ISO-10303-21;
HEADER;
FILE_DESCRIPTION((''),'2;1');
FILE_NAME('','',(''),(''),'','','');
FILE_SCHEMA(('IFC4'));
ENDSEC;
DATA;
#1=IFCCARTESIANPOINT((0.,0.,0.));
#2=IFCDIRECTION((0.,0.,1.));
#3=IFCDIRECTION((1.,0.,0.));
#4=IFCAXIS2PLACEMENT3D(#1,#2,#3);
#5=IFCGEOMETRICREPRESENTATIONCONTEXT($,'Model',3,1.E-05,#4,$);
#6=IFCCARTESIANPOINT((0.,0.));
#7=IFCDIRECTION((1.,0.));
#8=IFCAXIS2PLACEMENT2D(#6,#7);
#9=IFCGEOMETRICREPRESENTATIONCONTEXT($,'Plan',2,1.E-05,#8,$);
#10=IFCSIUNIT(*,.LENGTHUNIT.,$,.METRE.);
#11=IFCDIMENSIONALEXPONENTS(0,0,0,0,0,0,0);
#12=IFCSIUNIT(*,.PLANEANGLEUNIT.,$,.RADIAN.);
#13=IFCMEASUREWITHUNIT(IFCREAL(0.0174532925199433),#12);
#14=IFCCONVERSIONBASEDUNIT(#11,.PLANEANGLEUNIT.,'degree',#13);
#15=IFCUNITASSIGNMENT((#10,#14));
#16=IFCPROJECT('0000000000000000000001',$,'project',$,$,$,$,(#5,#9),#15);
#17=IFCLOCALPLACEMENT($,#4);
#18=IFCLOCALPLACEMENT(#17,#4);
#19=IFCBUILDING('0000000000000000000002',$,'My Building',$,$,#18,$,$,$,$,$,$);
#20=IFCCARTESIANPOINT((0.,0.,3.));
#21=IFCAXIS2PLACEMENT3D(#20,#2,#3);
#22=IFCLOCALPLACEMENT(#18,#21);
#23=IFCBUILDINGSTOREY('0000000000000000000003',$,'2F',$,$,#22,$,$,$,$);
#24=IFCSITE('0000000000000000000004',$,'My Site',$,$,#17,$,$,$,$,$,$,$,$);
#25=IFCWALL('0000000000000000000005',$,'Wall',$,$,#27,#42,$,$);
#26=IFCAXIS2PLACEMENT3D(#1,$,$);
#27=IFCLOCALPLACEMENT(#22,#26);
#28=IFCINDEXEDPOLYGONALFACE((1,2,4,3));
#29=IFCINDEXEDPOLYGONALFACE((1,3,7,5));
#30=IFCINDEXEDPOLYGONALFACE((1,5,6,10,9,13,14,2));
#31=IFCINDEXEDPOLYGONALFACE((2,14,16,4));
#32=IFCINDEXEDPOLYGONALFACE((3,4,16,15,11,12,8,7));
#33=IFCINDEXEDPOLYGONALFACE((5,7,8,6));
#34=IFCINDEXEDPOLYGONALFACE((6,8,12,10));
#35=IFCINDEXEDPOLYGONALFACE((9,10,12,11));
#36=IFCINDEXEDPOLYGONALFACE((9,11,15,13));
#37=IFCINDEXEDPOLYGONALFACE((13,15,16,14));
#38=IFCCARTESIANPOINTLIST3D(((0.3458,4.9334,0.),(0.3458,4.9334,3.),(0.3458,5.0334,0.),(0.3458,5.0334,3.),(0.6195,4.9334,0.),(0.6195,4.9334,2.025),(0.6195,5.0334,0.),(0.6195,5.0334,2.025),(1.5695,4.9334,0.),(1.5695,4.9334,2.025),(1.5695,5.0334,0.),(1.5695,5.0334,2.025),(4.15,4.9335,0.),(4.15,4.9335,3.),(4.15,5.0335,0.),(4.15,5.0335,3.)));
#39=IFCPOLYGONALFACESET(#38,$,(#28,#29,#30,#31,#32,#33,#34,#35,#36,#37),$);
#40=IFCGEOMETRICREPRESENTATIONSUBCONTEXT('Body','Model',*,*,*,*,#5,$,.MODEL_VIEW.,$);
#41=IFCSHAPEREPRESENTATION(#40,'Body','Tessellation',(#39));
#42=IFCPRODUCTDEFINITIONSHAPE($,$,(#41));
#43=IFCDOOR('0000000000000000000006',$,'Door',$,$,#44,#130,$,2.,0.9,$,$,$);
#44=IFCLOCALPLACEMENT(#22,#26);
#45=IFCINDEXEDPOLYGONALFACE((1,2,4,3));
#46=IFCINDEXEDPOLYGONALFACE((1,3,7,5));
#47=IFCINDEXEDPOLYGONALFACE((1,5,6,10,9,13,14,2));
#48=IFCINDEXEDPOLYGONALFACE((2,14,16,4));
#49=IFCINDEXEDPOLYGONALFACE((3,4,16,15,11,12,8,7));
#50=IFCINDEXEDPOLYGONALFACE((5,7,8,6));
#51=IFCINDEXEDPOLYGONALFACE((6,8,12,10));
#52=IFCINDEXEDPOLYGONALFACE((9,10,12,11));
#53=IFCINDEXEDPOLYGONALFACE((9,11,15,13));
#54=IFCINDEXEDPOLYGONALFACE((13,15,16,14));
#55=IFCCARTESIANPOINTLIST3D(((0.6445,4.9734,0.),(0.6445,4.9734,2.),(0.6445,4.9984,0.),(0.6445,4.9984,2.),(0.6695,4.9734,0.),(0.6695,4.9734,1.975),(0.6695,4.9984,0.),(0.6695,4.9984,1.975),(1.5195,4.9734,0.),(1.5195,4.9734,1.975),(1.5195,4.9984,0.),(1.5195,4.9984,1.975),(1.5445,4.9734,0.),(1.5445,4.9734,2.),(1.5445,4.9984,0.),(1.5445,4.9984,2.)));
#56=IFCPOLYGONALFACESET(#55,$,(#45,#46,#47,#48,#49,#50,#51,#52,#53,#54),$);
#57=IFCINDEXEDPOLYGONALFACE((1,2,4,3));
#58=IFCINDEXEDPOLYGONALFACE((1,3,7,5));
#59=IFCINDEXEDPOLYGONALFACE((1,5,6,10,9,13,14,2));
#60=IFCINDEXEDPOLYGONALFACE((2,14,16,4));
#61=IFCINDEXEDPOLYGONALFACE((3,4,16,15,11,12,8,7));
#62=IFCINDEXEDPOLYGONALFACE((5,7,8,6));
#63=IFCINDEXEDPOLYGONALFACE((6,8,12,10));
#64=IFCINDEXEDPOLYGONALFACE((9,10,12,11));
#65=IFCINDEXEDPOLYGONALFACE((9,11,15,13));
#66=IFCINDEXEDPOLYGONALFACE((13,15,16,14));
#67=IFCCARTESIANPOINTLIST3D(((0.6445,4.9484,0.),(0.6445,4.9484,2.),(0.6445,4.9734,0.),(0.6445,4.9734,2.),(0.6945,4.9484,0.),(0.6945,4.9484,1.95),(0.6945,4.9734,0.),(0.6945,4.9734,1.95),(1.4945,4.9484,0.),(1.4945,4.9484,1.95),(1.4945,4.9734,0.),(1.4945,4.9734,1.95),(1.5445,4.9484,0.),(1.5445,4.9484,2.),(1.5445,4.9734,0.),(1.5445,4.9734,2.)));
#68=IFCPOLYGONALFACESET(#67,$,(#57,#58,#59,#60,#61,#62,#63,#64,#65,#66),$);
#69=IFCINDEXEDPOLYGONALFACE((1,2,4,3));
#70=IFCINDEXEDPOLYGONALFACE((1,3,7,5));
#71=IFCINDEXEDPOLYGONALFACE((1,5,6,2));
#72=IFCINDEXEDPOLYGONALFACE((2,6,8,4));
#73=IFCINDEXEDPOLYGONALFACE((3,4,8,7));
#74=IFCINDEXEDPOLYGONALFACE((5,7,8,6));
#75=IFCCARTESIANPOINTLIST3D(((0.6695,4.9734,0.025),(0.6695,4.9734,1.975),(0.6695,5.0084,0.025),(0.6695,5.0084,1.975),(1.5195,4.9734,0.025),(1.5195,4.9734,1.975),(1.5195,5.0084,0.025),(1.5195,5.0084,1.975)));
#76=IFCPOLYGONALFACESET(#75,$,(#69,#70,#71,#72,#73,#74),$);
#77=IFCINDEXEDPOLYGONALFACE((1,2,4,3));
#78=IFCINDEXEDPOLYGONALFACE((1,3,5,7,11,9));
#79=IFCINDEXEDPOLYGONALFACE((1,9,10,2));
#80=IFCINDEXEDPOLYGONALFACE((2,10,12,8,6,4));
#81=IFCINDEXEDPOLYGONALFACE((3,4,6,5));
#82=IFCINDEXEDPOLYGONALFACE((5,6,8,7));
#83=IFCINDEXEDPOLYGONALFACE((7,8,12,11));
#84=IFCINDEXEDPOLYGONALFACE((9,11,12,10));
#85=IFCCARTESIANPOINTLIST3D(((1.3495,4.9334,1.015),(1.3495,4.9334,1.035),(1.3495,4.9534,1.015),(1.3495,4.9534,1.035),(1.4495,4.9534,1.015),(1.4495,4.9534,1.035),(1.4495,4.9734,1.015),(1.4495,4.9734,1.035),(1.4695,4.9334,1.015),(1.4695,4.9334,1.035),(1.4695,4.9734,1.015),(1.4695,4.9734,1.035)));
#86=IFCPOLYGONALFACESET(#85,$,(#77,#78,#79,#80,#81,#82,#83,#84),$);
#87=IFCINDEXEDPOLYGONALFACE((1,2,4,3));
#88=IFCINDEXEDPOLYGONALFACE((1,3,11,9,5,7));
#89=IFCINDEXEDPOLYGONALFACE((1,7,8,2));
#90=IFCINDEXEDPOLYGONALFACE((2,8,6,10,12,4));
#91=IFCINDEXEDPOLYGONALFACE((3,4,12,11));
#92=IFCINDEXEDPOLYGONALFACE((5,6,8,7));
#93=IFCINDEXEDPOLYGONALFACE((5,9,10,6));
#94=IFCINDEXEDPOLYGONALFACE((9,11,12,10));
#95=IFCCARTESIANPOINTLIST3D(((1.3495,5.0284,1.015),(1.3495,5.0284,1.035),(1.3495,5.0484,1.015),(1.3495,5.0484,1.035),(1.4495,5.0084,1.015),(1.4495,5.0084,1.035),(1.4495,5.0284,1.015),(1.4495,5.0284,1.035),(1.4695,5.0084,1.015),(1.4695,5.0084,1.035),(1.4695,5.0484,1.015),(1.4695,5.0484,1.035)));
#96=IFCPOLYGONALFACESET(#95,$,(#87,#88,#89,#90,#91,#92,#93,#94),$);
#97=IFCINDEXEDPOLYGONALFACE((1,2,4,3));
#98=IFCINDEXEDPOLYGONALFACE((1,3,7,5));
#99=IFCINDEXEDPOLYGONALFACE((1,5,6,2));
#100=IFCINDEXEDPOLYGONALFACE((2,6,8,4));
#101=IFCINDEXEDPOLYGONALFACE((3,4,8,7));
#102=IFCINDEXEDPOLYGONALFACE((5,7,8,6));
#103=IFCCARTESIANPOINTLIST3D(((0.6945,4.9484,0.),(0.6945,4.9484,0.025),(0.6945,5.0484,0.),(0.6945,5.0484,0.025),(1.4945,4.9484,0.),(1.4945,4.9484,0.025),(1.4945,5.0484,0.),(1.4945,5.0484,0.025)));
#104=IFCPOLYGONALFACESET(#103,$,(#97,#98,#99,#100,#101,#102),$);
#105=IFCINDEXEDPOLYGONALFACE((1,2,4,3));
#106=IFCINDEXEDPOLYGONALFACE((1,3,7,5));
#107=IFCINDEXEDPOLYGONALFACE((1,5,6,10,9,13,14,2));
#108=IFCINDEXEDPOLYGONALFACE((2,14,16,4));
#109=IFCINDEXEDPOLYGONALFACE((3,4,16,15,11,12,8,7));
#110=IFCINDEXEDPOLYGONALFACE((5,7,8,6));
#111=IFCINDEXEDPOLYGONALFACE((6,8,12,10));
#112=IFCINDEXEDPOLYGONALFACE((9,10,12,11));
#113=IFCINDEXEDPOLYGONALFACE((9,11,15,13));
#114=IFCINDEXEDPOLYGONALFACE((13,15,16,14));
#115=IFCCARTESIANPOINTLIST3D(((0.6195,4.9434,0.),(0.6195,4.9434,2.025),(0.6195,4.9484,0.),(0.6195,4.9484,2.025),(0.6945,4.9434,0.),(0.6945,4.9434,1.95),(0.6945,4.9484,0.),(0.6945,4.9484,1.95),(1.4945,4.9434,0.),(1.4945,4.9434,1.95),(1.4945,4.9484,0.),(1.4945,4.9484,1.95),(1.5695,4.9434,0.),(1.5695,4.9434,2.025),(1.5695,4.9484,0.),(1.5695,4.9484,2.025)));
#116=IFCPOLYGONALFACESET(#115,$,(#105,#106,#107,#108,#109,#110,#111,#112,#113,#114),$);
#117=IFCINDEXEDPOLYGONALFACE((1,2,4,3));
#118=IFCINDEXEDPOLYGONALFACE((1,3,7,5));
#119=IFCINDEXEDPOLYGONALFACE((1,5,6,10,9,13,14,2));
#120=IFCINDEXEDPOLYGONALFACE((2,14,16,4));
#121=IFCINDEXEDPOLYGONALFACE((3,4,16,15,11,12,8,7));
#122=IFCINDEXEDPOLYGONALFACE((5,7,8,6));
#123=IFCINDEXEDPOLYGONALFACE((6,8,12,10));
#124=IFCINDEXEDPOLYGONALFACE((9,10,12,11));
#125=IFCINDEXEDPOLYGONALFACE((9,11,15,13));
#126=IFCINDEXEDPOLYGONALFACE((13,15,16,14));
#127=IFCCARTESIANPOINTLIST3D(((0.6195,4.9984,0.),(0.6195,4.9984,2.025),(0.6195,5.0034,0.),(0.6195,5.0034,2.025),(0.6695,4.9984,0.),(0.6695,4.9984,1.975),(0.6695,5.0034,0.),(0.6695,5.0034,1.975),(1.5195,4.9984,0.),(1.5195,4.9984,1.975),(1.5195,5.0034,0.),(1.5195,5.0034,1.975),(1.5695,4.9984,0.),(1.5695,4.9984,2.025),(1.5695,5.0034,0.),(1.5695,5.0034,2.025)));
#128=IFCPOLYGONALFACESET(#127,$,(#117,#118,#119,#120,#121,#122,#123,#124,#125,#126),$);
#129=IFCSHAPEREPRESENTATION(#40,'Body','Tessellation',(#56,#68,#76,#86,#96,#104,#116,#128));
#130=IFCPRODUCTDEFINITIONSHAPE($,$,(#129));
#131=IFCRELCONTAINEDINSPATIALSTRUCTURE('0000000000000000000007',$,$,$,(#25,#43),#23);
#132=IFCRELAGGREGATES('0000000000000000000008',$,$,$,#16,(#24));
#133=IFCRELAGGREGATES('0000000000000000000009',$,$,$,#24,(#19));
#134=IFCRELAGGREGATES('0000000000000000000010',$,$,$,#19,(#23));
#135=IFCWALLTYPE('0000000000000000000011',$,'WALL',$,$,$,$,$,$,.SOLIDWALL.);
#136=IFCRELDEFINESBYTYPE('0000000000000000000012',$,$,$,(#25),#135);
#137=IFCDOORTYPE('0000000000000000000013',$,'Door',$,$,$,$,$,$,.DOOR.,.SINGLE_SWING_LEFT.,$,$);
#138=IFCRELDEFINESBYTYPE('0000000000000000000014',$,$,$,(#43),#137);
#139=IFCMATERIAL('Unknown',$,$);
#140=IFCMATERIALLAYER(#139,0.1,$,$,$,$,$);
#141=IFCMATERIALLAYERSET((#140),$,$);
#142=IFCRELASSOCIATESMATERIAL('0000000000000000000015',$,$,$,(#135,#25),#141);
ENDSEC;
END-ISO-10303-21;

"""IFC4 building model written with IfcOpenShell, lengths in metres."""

from ifc_helpers import new_model, entity, si_unit, converted_unit, frame, origin_with_axes, origin_2d_with_axis, place, context, subcontext, project, spatial, line, indexed_curve, outline, extrude, shape, source, transform, mapped, material, layer, layer_set, layer_usage, type_object, type_shapes, element, fill, save


model = new_model("IFC4")

# Units and contexts
model_context = context("Model", 3, precision=1e-05, world=origin_with_axes())
plan_context = context("Plan", 2, precision=1e-05, world=origin_2d_with_axis())
body_context_1 = subcontext(model_context, "Body", "Model", "MODEL_VIEW")
body_context_2 = subcontext(plan_context, "Body", "Plan", "PLAN_VIEW")
ifc_project = project(units=[si_unit("LENGTHUNIT", "METRE"), converted_unit("PLANEANGLEUNIT", "degree", entity("IfcReal", 0.0174532925199433), si_unit("PLANEANGLEUNIT", "RADIAN"), dimensions=[0, 0, 0, 0, 0, 0, 0])], contexts=[model_context, plan_context])

# Site, building, storey
site_placement = place(None, origin_with_axes())
site = spatial("IfcSite", under=ifc_project, at=site_placement, Name="My Site")
building_placement = place(site_placement, origin_with_axes())
building = spatial("IfcBuilding", under=site, at=building_placement, Name="My Building")
storey_placement = place(building_placement, frame((0.0, 0.0, 3.0), z_axis=(0.0, 0.0, 1.0), x_axis=(1.0, 0.0, 0.0)))
storey = spatial("IfcBuildingStorey", under=building, at=storey_placement, Name="2F")

# Shared definitions
ifc_material = material(Name="Unknown")

# Shared definitions
ifc_layer_1 = layer(ifc_material, 0.1)
ifc_layer_set_1 = layer_set([ifc_layer_1])
wall_type = type_object("IfcWallType", Name="WALL", PredefinedType="SOLIDWALL", material=ifc_layer_set_1)

# Shared definitions
shared_shape_1 = source(origin_with_axes(), body_context_1, "Body", "SweptSolid", [
    extrude(outline(indexed_curve([(0.0, 0.0), (0.9, 0.0), (0.9, 2.0), (0.0, 2.0)], segments=[line(1, 2, 3, 4, 1)])), frame((0.0, -0.6, 0.0), z_axis=(0.0, -1.0, 0.0), x_axis=(1.0, 0.0, 0.0)), (0.0, 0.0, -1.0), 1.2),
])
door_type = type_object("IfcDoorType", Name="Door", OperationType="SINGLE_SWING_LEFT", PredefinedType="DOOR")
shared_shape_2 = source(origin_with_axes(), body_context_1, "Body", "SweptSolid", [
    extrude(outline(indexed_curve([(0.0, 0.0), (0.0, 2.0), (0.9, 2.0), (0.9, 0.0), (0.875, 0.0), (0.875, 1.975), (0.025, 1.975), (0.025, 0.0)], segments=[line(1, 2, 3, 4, 5, 6, 7, 8, 1)])), frame((0.0, 0.025, 0.0), z_axis=(0.0, -1.0, 0.0), x_axis=(1.0, 0.0, 0.0)), (0.0, 0.0, -1.0), 0.025),
    extrude(outline(indexed_curve([(0.0, 0.0), (0.0, 2.0), (0.9, 2.0), (0.9, 0.0), (0.85, 0.0), (0.85, 1.95), (0.05, 1.95), (0.05, 0.0)], segments=[line(1, 2, 3, 4, 5, 6, 7, 8, 1)])), frame((0.0, 0.0, 0.0), z_axis=(0.0, -1.0, 0.0), x_axis=(1.0, 0.0, 0.0)), (0.0, 0.0, -1.0), 0.025),
    extrude(outline(indexed_curve([(0.0, 0.0), (0.85, 0.0), (0.85, 0.035), (0.0, 0.035)], segments=[line(1, 2, 3, 4, 1)])), frame((0.025, 0.025, 0.025), z_axis=(0.0, 0.0, 1.0), x_axis=(1.0, 0.0, 0.0)), (0.0, 0.0, 1.0), 1.95),
    extrude(outline(indexed_curve([(0.0, 0.0), (0.0, -0.04), (-0.12, -0.04), (-0.12, -0.02), (-0.02, -0.02), (-0.02, 0.0)], segments=[line(1, 2, 3, 4, 5, 6, 1)])), frame((0.825, 0.025, 1.015), z_axis=(0.0, 0.0, 1.0), x_axis=(1.0, 0.0, 0.0)), (0.0, 0.0, 1.0), 0.02),
    extrude(outline(indexed_curve([(0.0, 0.0), (0.0, 0.04), (-0.12, 0.04), (-0.12, 0.02), (-0.02, 0.02), (-0.02, 0.0)], segments=[line(1, 2, 3, 4, 5, 6, 1)])), frame((0.825, 0.06, 1.015), z_axis=(0.0, 0.0, 1.0), x_axis=(1.0, 0.0, 0.0)), (0.0, 0.0, 1.0), 0.02),
    extrude(outline(indexed_curve([(0.0, 0.0), (0.8, 0.0), (0.8, 0.1), (0.0, 0.1)], segments=[line(1, 2, 3, 4, 1)])), frame((0.05, 0.0, 0.0), z_axis=(0.0, 0.0, 1.0), x_axis=(1.0, 0.0, 0.0)), (0.0, 0.0, 1.0), 0.025),
    extrude(outline(indexed_curve([(0.0, 0.0), (0.0, 2.025), (0.95, 2.025), (0.95, 0.0), (0.875, 0.0), (0.875, 1.95), (0.075, 1.95), (0.075, 0.0)], segments=[line(1, 2, 3, 4, 5, 6, 7, 8, 1)])), frame((-0.025, -0.005, 0.0), z_axis=(0.0, -1.0, 0.0), x_axis=(1.0, 0.0, 0.0)), (0.0, 0.0, -1.0), 0.005),
    extrude(outline(indexed_curve([(0.0, 0.0), (0.0, 2.025), (0.95, 2.025), (0.95, 0.0), (0.9, 0.0), (0.9, 1.975), (0.05, 1.975), (0.05, 0.0)], segments=[line(1, 2, 3, 4, 5, 6, 7, 8, 1)])), frame((-0.025, 0.05, 0.0), z_axis=(0.0, -1.0, 0.0), x_axis=(1.0, 0.0, 0.0)), (0.0, 0.0, -1.0), 0.005),
])
shared_shape_3 = source(origin_with_axes(), body_context_2, "Body", "Curve2D", [
    entity("IfcIndexedPolyCurve", entity("IfcCartesianPointList2D", [[0.0, 0.0], [0.0, 0.05], [0.025, 0.05], [0.025, 0.025], [0.05, 0.025], [0.05, 0.0]]), [entity("IfcLineIndex", [1, 2, 3, 4, 5, 6, 1])]),
    entity("IfcIndexedPolyCurve", entity("IfcCartesianPointList2D", [[0.9, 0.0], [0.9, 0.05], [0.875, 0.05], [0.875, 0.025], [0.85, 0.025], [0.85, 0.0]]), [entity("IfcLineIndex", [1, 2, 3, 4, 5, 6, 1])]),
    entity("IfcTrimmedCurve", entity("IfcEllipse", entity("IfcAxis2Placement2D", entity("IfcCartesianPoint", [0.06, 0.05]), entity("IfcDirection", [1.0, 0.0])), 0.815, 0.85), [entity("IfcCartesianPoint", [0.875, 0.05])], [entity("IfcCartesianPoint", [0.06, 0.9])], True, "CARTESIAN"),
    entity("IfcIndexedPolyCurve", entity("IfcCartesianPointList2D", [[0.025, 0.05], [0.06, 0.05], [0.06, 0.9], [0.025, 0.9]]), [entity("IfcLineIndex", [1, 2, 3, 4, 1])]),
])
type_shapes(door_type, [shared_shape_2, shared_shape_3])

# Wall, openings, door
ifc_layer_usage_1 = layer_usage(ifc_layer_set_1, "AXIS2", "POSITIVE", 0.0)
wall_1_placement = place(storey_placement, frame((4.15, 5.0335, 0.0), z_axis=(0.0, 0.0, 1.0), x_axis=(-1.0, -0.000042, 0.0)))
wall_1 = element("IfcWall", 1, at=wall_1_placement, inside=storey, type_object=wall_type, material=ifc_layer_usage_1, Name="Wall", context=body_context_1, shape_type="SweptSolid", body=[
    extrude(outline(indexed_curve([(0.0, 0.0), (0.0, 0.1), (3.8042, 0.1), (3.8042, 0.0)], segments=[line(1, 2, 3, 4, 1)])), origin_with_axes(), (0.0, 0.0, 1.0), 3.0),
])
opening_1_placement = place(wall_1_placement, frame((2.6055, 0.0, 0.0), z_axis=(0.0, 0.0, 1.0), x_axis=(1.0, 0.0, 0.0)))
opening_1 = element("IfcOpeningElement", 2, at=opening_1_placement, cuts=wall_1, PredefinedType="OPENING", context=body_context_1, shape_type="MappedRepresentation", body=[
    mapped(shared_shape_1, transform((0.0, 0.0, 0.0), x_axis=(1.0, 0.0, 0.0), y_axis=(0.0, 1.0, 0.0), z_axis=(0.0, 0.0, 1.0), scale=1.0)),
])
shared_shape_4 = source(origin_with_axes(), body_context_1, "Body", "SweptSolid", [
    extrude(outline(indexed_curve([(0.0, 0.0), (0.95, 0.0), (0.95, 2.025), (0.0, 2.025)], segments=[line(1, 2, 3, 4, 1)])), frame((-0.025, -0.6, 0.0), z_axis=(0.0, -1.0, 0.0), x_axis=(1.0, 0.0, 0.0)), (0.0, 0.0, -1.0), 1.2),
])
opening_2_placement = place(wall_1_placement, frame((2.6055, 0.0, 0.0), z_axis=(0.0, 0.0, 1.0), x_axis=(1.0, 0.0, 0.0)))
element("IfcOpeningElement", 3, at=opening_2_placement, cuts=wall_1, PredefinedType="OPENING", context=body_context_1, shape_type="MappedRepresentation", body=[
    mapped(shared_shape_4, transform((0.0, 0.0, 0.0), x_axis=(1.0, 0.0, 0.0), y_axis=(0.0, 1.0, 0.0), z_axis=(0.0, 0.0, 1.0), scale=1.0)),
])
door_1_placement = place(opening_1_placement, frame((0.9, 0.085, 0.0), z_axis=(0.0, 0.0, 1.0), x_axis=(-1.0, 0.0, 0.0)))
door_1 = element("IfcDoor", 4, at=door_1_placement, inside=storey, type_object=door_type, Name="Door", OverallHeight=2.0, OverallWidth=0.9, shapes=[
    shape(body_context_1, "Body", "MappedRepresentation", [mapped(shared_shape_2, transform((0.0, 0.0, 0.0), x_axis=(1.0, 0.0, 0.0), y_axis=(0.0, 1.0, 0.0), z_axis=(0.0, 0.0, 1.0), scale=1.0))]),
    shape(body_context_2, "Body", "MappedRepresentation", [mapped(shared_shape_3, transform((0.0, 0.0, 0.0), x_axis=(1.0, 0.0, 0.0), y_axis=(0.0, 1.0, 0.0), z_axis=(0.0, 0.0, 1.0), scale=1.0))]),
])
fill(opening_1, door_1)

save(model, "model.ifc")
